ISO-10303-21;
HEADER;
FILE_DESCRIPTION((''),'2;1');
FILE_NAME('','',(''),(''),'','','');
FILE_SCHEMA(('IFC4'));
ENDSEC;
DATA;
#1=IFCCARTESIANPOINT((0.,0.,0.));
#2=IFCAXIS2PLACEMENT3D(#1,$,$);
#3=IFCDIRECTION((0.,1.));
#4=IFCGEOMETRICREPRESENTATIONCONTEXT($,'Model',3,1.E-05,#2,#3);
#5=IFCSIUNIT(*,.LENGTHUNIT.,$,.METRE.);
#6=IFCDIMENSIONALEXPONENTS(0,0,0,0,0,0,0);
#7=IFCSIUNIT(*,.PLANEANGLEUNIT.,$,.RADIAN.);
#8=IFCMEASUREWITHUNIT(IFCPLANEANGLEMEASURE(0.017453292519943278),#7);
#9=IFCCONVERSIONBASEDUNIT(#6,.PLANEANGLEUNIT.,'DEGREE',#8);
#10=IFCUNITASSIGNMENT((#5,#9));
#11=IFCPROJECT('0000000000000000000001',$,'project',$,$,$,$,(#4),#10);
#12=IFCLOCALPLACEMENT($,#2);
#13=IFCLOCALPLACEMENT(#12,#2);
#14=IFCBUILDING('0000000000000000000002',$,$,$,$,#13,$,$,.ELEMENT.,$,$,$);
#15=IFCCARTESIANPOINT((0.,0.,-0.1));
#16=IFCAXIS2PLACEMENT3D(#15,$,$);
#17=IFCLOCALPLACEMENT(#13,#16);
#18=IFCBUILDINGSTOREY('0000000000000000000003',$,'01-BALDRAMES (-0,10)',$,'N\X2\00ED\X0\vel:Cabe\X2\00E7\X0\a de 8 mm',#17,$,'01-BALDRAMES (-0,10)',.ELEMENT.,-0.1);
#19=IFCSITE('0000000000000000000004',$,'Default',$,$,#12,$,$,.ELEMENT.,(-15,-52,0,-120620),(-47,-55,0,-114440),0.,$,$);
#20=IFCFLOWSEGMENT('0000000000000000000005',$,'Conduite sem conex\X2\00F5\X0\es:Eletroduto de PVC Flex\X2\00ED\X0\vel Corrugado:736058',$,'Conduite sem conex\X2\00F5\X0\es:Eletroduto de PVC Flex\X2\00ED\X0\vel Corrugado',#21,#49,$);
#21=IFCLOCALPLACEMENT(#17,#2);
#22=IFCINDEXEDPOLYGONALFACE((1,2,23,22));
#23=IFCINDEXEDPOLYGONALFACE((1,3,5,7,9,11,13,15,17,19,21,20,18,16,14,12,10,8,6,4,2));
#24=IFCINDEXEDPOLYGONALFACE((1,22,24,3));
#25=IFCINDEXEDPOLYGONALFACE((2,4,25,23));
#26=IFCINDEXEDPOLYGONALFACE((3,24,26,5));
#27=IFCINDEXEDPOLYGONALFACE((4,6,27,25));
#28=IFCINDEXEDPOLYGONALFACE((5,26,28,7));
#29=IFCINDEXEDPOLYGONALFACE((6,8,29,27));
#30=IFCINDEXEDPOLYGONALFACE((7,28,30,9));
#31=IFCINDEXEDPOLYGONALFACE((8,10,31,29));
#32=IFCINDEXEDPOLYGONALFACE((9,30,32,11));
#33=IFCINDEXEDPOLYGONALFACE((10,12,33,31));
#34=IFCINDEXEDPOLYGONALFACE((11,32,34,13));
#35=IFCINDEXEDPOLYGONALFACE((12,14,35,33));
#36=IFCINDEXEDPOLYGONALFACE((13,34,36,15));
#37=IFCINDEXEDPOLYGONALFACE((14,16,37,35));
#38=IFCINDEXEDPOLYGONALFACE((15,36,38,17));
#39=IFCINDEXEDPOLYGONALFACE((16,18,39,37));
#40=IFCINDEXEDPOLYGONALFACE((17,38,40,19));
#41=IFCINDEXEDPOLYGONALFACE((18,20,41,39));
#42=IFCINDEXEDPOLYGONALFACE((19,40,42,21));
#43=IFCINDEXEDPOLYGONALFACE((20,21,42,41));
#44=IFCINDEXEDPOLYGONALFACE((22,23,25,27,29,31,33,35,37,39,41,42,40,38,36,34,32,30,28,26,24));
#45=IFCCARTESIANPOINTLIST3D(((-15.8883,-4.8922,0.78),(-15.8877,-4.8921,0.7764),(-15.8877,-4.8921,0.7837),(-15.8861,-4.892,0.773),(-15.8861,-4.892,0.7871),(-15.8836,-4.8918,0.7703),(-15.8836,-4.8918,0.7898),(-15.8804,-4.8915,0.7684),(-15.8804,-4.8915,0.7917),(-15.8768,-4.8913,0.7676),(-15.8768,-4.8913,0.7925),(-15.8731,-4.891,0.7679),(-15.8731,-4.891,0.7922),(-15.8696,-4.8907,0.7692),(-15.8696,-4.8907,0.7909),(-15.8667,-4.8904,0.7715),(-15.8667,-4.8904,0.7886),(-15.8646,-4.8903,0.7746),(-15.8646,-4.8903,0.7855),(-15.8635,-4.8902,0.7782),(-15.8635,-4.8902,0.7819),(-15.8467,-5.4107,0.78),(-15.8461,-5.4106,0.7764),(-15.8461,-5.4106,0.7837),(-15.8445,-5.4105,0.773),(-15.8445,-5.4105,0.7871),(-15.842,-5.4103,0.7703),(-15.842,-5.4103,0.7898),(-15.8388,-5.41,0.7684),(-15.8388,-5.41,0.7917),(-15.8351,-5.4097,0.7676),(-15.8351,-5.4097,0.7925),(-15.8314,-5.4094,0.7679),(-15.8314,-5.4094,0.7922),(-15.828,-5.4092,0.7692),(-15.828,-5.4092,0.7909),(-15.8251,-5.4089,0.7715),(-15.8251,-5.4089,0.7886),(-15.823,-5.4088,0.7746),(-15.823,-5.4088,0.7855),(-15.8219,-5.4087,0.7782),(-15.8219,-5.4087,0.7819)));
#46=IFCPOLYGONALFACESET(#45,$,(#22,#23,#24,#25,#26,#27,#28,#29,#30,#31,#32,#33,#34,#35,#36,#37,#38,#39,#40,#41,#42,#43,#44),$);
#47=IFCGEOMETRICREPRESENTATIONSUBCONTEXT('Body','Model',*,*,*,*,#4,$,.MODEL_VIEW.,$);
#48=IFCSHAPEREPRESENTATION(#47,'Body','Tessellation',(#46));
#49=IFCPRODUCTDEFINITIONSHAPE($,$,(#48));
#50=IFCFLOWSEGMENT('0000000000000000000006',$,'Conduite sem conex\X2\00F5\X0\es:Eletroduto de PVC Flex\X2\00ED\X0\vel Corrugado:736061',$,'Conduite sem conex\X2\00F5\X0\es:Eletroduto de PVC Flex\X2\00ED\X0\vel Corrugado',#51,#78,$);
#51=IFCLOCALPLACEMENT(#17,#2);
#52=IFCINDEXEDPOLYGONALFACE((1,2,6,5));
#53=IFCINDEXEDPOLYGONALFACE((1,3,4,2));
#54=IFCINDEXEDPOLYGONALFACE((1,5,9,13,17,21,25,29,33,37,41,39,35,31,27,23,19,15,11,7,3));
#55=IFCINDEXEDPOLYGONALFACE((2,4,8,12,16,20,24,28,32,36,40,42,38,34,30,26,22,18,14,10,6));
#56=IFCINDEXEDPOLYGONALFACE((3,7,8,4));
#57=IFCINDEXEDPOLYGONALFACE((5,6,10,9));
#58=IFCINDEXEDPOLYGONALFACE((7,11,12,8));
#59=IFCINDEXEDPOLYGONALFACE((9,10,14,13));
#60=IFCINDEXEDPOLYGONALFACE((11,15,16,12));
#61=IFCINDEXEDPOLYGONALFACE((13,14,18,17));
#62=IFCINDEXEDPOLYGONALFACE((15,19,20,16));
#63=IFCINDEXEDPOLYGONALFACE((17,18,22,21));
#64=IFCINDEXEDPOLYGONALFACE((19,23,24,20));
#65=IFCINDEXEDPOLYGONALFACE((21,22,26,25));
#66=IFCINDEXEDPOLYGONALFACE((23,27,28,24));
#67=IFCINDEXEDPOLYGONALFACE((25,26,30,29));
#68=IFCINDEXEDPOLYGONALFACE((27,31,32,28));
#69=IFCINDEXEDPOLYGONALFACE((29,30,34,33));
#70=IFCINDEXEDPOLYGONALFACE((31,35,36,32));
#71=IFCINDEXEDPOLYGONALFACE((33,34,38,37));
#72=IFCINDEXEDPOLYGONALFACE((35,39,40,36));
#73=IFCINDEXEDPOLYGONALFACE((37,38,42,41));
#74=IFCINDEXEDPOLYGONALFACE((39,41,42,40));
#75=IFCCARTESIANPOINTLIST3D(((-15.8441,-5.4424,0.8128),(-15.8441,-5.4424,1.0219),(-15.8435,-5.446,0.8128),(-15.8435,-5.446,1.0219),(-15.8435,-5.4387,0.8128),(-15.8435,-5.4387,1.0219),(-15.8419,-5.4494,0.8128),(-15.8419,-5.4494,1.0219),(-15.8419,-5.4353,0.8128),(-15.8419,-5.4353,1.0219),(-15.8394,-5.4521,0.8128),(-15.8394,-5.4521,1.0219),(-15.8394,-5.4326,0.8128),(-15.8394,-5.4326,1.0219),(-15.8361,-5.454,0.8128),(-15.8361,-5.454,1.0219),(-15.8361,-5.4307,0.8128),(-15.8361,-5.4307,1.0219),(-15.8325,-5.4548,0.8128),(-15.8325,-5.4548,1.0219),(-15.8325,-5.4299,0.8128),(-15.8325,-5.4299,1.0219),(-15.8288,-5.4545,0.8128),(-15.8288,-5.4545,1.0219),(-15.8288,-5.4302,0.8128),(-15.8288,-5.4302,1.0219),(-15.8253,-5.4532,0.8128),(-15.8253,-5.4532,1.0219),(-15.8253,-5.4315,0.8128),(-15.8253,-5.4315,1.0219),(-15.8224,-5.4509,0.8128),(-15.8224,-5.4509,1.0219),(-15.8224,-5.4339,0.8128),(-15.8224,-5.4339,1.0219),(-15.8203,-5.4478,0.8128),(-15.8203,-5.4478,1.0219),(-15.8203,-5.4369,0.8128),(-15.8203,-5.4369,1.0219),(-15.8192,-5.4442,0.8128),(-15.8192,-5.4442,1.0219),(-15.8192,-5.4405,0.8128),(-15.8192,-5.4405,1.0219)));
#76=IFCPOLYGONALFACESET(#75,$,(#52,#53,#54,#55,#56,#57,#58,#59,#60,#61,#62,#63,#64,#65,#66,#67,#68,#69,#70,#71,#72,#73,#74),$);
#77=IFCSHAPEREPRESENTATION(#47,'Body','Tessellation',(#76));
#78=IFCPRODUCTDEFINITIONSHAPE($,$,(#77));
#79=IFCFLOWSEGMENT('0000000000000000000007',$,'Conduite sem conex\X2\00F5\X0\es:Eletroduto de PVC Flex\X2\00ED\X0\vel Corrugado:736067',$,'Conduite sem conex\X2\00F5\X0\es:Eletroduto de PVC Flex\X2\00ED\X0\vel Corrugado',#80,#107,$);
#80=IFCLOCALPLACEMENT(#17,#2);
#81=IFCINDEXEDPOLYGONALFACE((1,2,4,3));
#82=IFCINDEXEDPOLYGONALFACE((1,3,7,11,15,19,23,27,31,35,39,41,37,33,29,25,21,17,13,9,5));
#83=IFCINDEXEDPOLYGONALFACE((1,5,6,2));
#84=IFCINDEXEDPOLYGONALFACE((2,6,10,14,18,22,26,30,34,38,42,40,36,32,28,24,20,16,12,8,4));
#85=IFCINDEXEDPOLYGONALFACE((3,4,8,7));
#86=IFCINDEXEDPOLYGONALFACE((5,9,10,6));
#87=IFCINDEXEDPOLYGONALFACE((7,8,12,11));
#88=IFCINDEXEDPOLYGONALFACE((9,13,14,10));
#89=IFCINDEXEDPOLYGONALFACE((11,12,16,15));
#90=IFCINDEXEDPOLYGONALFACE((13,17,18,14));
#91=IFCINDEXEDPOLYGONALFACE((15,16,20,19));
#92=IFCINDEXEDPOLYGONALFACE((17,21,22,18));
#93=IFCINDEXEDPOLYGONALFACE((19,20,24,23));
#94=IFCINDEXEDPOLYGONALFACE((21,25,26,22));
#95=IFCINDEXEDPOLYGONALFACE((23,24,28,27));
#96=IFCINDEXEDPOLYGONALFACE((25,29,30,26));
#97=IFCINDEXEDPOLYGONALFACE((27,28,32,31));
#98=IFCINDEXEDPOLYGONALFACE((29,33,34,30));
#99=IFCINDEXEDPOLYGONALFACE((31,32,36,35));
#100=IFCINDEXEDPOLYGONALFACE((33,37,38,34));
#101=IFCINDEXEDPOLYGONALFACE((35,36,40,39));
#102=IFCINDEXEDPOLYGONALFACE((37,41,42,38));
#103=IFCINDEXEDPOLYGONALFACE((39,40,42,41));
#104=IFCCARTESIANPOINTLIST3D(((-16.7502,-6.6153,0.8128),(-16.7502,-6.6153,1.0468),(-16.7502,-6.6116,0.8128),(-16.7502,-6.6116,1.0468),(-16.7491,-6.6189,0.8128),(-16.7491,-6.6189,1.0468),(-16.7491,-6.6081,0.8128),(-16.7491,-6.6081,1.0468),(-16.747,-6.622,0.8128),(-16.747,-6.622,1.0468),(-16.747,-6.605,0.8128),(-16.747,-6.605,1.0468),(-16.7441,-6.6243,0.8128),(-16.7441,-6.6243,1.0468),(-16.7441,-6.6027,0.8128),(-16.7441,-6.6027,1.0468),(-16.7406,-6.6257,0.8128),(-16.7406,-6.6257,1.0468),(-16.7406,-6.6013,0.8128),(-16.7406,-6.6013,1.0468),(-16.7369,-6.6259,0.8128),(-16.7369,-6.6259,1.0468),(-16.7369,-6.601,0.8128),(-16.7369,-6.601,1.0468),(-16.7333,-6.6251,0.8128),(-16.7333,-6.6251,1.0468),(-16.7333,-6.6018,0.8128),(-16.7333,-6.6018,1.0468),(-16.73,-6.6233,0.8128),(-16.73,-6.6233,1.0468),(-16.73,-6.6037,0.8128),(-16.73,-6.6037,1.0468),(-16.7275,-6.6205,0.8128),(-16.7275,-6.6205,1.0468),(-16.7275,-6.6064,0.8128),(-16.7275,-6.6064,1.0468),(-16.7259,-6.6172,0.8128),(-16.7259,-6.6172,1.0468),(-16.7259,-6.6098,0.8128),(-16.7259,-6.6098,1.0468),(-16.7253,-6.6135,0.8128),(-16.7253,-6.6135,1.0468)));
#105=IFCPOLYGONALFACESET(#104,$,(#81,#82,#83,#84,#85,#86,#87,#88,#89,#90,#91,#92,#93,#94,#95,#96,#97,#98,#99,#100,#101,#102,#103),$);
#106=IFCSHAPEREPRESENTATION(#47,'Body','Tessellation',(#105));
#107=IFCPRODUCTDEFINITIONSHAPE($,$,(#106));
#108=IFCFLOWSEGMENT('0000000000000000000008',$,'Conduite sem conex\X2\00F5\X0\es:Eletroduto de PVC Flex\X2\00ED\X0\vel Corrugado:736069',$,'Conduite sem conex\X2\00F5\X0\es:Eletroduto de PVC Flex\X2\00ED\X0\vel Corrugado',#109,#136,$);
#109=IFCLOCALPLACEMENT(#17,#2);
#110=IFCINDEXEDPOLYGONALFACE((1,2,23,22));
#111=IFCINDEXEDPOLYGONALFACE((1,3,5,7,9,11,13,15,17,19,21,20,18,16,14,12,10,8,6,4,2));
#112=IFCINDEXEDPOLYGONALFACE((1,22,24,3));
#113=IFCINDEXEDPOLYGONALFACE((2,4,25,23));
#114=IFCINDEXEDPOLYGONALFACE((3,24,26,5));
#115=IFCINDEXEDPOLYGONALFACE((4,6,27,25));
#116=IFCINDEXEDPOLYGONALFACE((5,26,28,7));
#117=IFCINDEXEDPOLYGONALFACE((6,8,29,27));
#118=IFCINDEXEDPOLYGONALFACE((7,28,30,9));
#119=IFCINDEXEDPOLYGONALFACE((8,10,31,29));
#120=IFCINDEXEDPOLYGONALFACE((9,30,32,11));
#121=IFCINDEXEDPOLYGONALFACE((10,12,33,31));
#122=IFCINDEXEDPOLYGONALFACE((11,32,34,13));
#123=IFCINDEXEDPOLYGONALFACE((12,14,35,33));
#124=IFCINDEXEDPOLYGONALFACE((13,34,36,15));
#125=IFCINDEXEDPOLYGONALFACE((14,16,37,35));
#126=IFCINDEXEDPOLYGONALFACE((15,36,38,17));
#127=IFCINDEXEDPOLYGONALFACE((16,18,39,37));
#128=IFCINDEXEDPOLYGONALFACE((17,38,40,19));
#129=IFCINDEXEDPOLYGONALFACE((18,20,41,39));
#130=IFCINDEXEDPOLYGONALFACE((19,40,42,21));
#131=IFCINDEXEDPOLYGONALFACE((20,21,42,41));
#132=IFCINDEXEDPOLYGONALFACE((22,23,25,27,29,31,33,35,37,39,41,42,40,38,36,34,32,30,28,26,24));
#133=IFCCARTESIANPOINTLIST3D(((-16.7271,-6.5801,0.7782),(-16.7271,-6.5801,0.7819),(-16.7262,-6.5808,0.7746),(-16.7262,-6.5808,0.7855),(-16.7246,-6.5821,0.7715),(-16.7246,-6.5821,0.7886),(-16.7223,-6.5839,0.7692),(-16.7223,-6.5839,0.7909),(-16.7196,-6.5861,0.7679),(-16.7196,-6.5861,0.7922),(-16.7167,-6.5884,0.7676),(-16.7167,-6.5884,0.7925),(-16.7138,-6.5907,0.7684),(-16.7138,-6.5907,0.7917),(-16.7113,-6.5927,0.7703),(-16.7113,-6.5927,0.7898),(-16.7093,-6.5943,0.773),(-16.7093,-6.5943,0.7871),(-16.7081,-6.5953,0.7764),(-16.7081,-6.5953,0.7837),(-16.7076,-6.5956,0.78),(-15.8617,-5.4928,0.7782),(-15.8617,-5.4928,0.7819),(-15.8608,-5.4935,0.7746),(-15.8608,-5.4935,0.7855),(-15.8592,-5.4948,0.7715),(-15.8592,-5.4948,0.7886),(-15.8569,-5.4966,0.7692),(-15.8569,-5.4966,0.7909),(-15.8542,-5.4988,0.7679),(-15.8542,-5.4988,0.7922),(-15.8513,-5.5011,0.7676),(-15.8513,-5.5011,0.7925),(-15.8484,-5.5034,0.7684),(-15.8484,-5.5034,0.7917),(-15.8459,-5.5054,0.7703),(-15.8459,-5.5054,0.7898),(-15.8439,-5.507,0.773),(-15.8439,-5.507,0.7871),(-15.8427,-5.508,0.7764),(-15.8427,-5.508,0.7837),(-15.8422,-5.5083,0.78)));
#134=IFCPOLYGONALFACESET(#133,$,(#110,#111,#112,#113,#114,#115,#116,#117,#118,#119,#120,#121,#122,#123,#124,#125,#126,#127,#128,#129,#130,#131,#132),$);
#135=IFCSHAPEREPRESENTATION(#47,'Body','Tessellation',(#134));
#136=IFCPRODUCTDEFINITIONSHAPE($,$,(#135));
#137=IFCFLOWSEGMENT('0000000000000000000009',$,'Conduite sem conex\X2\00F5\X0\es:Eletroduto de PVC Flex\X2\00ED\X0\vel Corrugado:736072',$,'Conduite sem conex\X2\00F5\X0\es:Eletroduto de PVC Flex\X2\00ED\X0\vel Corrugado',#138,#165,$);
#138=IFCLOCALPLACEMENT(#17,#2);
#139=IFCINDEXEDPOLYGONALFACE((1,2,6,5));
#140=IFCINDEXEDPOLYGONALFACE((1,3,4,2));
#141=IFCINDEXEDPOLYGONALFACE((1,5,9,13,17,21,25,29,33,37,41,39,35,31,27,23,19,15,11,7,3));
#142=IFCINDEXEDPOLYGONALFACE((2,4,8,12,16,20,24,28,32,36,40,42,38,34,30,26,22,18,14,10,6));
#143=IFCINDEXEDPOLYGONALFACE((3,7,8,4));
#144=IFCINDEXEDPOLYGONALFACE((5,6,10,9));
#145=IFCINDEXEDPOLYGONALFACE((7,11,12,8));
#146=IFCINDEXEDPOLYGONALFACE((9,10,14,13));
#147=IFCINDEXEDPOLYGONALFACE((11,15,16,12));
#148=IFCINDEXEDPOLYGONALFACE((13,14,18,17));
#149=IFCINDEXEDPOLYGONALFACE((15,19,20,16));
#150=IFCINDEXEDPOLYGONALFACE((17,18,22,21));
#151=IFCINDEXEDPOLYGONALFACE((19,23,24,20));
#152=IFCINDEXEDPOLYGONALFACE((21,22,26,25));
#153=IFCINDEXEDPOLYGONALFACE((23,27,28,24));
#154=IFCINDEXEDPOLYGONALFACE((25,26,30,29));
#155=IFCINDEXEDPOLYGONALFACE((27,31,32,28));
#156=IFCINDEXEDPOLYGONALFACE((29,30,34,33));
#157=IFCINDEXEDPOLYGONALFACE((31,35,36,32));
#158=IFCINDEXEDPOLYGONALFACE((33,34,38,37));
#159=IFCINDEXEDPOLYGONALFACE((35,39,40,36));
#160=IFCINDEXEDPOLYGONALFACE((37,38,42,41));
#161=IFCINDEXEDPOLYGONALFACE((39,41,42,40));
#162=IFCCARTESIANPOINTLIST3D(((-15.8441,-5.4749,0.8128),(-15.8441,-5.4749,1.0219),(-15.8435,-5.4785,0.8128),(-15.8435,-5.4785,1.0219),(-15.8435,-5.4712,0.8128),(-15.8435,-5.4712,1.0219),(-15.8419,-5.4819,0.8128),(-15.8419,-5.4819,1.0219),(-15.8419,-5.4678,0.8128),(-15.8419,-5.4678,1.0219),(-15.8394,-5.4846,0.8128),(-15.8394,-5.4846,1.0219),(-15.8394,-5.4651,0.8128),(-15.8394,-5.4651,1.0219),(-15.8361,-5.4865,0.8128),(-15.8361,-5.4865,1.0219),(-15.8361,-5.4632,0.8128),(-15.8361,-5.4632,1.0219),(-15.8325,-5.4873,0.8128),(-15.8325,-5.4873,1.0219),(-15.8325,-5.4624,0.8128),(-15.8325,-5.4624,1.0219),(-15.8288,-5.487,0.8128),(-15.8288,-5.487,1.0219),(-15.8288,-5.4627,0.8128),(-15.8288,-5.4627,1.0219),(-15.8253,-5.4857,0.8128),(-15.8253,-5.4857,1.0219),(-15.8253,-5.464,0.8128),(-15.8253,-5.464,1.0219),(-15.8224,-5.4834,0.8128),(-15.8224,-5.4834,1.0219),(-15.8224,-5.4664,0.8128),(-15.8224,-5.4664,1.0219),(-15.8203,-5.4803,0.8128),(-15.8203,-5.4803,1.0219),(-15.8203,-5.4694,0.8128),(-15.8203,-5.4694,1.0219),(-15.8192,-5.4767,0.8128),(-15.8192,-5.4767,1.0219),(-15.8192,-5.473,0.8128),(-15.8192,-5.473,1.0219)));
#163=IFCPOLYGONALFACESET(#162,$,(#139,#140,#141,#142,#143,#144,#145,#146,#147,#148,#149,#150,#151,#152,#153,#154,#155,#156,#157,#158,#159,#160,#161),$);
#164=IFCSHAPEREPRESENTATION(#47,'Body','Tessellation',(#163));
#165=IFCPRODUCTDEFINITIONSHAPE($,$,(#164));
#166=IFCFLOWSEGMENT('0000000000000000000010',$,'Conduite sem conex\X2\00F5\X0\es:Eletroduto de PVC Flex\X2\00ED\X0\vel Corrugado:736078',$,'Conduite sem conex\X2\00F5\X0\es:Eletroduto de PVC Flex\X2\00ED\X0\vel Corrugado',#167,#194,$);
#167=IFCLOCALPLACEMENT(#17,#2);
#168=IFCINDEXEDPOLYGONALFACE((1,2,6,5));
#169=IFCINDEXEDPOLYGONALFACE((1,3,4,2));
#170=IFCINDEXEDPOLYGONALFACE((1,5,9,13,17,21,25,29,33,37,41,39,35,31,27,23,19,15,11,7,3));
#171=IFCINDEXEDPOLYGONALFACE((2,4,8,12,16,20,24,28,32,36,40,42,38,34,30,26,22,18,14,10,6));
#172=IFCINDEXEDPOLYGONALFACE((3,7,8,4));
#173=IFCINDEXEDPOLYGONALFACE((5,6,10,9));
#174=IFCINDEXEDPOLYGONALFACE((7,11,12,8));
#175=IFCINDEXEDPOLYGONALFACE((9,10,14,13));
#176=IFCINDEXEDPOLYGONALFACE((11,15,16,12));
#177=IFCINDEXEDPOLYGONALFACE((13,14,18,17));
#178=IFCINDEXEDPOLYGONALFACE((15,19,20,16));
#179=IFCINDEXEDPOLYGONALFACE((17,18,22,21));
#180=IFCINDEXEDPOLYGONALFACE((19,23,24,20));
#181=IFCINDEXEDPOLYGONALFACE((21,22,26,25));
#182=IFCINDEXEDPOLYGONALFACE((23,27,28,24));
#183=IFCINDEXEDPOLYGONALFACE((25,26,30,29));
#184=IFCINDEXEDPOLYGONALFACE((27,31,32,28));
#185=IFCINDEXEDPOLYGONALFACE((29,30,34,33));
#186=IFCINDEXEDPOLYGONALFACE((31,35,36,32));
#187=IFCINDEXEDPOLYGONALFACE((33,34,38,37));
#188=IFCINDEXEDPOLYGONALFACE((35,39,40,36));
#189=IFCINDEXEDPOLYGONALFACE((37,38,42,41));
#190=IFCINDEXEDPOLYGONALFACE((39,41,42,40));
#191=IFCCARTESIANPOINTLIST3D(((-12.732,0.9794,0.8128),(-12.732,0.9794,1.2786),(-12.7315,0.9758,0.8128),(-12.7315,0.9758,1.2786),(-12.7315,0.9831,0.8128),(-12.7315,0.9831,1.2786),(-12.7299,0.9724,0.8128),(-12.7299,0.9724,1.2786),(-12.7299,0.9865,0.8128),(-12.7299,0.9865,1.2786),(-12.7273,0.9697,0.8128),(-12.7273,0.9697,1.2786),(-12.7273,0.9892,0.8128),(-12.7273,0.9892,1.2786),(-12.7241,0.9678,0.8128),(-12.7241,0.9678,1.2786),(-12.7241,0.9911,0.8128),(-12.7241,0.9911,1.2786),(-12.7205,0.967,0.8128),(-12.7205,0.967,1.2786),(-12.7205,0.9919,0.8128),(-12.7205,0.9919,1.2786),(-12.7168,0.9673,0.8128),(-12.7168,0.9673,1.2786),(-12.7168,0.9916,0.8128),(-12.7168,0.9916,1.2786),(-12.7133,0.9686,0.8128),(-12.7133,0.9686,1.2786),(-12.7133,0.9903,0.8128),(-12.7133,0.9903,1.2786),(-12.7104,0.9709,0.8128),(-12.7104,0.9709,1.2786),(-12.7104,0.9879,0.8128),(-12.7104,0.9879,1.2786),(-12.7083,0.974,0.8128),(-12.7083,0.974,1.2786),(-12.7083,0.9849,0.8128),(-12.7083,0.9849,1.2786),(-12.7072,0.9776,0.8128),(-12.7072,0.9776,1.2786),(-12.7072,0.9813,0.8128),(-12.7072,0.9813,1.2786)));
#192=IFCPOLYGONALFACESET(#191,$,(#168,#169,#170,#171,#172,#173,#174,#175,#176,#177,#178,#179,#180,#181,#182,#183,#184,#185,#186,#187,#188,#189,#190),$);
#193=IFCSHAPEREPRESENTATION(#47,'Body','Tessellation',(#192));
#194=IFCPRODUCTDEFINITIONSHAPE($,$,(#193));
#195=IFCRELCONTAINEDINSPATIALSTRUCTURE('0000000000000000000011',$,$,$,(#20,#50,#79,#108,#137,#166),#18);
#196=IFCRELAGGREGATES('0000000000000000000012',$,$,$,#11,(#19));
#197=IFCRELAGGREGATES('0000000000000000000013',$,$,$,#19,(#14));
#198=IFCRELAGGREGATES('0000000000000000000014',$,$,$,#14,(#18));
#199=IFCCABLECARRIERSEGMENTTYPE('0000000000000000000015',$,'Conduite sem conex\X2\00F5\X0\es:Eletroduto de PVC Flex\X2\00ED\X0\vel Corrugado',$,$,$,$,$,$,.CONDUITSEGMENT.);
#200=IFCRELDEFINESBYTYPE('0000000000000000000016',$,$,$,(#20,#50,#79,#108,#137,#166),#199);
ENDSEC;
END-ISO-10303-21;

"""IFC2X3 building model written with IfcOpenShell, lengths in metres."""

from ifc_helpers import new_model, entity, si_unit, converted_unit, direction, frame, frame_2d, origin, origin_2d_with_axis, place, context, subcontext, project, spatial, circle, extrude, type_object, element, save


model = new_model("IFC2X3")

# Units and contexts
model_context = context("Model", 3, precision=1e-05, world=origin(), true_north=direction((0.0, 1.0)))
body_context = subcontext(model_context, "Body", "Model", "MODEL_VIEW")
ifc_project = project(units=[si_unit("LENGTHUNIT", "METRE"), converted_unit("PLANEANGLEUNIT", "DEGREE", entity("IfcPlaneAngleMeasure", 0.017453292519943278), si_unit("PLANEANGLEUNIT", "RADIAN"), dimensions=[0, 0, 0, 0, 0, 0, 0])], contexts=[model_context])

# Site, building, storey
site_placement = place(None, origin())
site = spatial("IfcSite", under=ifc_project, at=site_placement, Name="Default", CompositionType="ELEMENT", RefLatitude=(-15, -52, 0, -120620), RefLongitude=(-47, -55, 0, -114440), RefElevation=0.0)
building_placement = place(site_placement, origin())
building = spatial("IfcBuilding", under=site, at=building_placement, CompositionType="ELEMENT")
storey_placement = place(building_placement, frame((0.0, 0.0, -0.1)))
storey = spatial("IfcBuildingStorey", under=building, at=storey_placement, Name="01-BALDRAMES (-0,10)", ObjectType="Nível:Cabeça de 8 mm", LongName="01-BALDRAMES (-0,10)", CompositionType="ELEMENT", Elevation=-0.1)

# Flow segments
cable_carrier_segment_type = type_object("IfcCableCarrierSegmentType", Name="Conduite sem conexões:Eletroduto de PVC Flexível Corrugado", PredefinedType="CONDUITSEGMENT")
flow_segment_1_placement = place(storey_placement, origin())
element("IfcFlowSegment", 1, at=flow_segment_1_placement, inside=storey, type_object=cable_carrier_segment_type, Name="Conduite sem conexões:Eletroduto de PVC Flexível Corrugado:736058", ObjectType="Conduite sem conexões:Eletroduto de PVC Flexível Corrugado", context=body_context, shape_type="SweptSolid", body=[
    extrude(circle(Radius=0.0125, at=origin_2d_with_axis()), frame((-15.8758, -4.8912, 0.78), z_axis=(0.080053, -0.996791, 0.0), x_axis=(-0.996791, -0.080053, 0.0)), (0.0, 0.0, 1.0), 0.5202),
])
flow_segment_2_placement = place(storey_placement, origin())
element("IfcFlowSegment", 2, at=flow_segment_2_placement, inside=storey, type_object=cable_carrier_segment_type, Name="Conduite sem conexões:Eletroduto de PVC Flexível Corrugado:736061", ObjectType="Conduite sem conexões:Eletroduto de PVC Flexível Corrugado", context=body_context, shape_type="SweptSolid", body=[
    extrude(circle(Radius=0.0125, at=frame_2d((0.0, 0.0), x_axis=(1.0, 0.0))), frame((-15.8316, -5.4424, 0.8128), z_axis=(0.0, 0.0, 1.0), x_axis=(-1.0, 0.0, 0.0)), (0.0, 0.0, 1.0), 0.209),
])
flow_segment_3_placement = place(storey_placement, origin())
element("IfcFlowSegment", 3, at=flow_segment_3_placement, inside=storey, type_object=cable_carrier_segment_type, Name="Conduite sem conexões:Eletroduto de PVC Flexível Corrugado:736067", ObjectType="Conduite sem conexões:Eletroduto de PVC Flexível Corrugado", context=body_context, shape_type="SweptSolid", body=[
    extrude(circle(Radius=0.0125, at=frame_2d((0.0, 0.0), x_axis=(1.0, 0.0))), frame((-16.7378, -6.6135, 0.8128)), (0.0, 0.0, 1.0), 0.234),
])
flow_segment_4_placement = place(storey_placement, origin())
element("IfcFlowSegment", 4, at=flow_segment_4_placement, inside=storey, type_object=cable_carrier_segment_type, Name="Conduite sem conexões:Eletroduto de PVC Flexível Corrugado:736069", ObjectType="Conduite sem conexões:Eletroduto de PVC Flexível Corrugado", context=body_context, shape_type="SweptSolid", body=[
    extrude(circle(Radius=0.0125, at=origin_2d_with_axis()), frame((-16.7174, -6.5878, 0.78), z_axis=(0.622746, 0.782424, 0.0), x_axis=(0.782424, -0.622746, 0.0)), (0.0, 0.0, 1.0), 1.3896),
])
flow_segment_5_placement = place(storey_placement, origin())
element("IfcFlowSegment", 5, at=flow_segment_5_placement, inside=storey, type_object=cable_carrier_segment_type, Name="Conduite sem conexões:Eletroduto de PVC Flexível Corrugado:736072", ObjectType="Conduite sem conexões:Eletroduto de PVC Flexível Corrugado", context=body_context, shape_type="SweptSolid", body=[
    extrude(circle(Radius=0.0125, at=frame_2d((0.0, 0.0), x_axis=(1.0, 0.0))), frame((-15.8316, -5.4749, 0.8128), z_axis=(0.0, 0.0, 1.0), x_axis=(-1.0, 0.0, 0.0)), (0.0, 0.0, 1.0), 0.209),
])
flow_segment_6_placement = place(storey_placement, origin())
element("IfcFlowSegment", 6, at=flow_segment_6_placement, inside=storey, type_object=cable_carrier_segment_type, Name="Conduite sem conexões:Eletroduto de PVC Flexível Corrugado:736078", ObjectType="Conduite sem conexões:Eletroduto de PVC Flexível Corrugado", context=body_context, shape_type="SweptSolid", body=[
    extrude(circle(Radius=0.0125, at=frame_2d((0.0, 0.0), x_axis=(1.0, 0.0))), frame((-12.7195, 0.9794, 0.8128), z_axis=(0.0, 0.0, 1.0), x_axis=(-1.0, 0.0, 0.0)), (0.0, 0.0, 1.0), 0.4658),
])

save(model, "model.ifc")
